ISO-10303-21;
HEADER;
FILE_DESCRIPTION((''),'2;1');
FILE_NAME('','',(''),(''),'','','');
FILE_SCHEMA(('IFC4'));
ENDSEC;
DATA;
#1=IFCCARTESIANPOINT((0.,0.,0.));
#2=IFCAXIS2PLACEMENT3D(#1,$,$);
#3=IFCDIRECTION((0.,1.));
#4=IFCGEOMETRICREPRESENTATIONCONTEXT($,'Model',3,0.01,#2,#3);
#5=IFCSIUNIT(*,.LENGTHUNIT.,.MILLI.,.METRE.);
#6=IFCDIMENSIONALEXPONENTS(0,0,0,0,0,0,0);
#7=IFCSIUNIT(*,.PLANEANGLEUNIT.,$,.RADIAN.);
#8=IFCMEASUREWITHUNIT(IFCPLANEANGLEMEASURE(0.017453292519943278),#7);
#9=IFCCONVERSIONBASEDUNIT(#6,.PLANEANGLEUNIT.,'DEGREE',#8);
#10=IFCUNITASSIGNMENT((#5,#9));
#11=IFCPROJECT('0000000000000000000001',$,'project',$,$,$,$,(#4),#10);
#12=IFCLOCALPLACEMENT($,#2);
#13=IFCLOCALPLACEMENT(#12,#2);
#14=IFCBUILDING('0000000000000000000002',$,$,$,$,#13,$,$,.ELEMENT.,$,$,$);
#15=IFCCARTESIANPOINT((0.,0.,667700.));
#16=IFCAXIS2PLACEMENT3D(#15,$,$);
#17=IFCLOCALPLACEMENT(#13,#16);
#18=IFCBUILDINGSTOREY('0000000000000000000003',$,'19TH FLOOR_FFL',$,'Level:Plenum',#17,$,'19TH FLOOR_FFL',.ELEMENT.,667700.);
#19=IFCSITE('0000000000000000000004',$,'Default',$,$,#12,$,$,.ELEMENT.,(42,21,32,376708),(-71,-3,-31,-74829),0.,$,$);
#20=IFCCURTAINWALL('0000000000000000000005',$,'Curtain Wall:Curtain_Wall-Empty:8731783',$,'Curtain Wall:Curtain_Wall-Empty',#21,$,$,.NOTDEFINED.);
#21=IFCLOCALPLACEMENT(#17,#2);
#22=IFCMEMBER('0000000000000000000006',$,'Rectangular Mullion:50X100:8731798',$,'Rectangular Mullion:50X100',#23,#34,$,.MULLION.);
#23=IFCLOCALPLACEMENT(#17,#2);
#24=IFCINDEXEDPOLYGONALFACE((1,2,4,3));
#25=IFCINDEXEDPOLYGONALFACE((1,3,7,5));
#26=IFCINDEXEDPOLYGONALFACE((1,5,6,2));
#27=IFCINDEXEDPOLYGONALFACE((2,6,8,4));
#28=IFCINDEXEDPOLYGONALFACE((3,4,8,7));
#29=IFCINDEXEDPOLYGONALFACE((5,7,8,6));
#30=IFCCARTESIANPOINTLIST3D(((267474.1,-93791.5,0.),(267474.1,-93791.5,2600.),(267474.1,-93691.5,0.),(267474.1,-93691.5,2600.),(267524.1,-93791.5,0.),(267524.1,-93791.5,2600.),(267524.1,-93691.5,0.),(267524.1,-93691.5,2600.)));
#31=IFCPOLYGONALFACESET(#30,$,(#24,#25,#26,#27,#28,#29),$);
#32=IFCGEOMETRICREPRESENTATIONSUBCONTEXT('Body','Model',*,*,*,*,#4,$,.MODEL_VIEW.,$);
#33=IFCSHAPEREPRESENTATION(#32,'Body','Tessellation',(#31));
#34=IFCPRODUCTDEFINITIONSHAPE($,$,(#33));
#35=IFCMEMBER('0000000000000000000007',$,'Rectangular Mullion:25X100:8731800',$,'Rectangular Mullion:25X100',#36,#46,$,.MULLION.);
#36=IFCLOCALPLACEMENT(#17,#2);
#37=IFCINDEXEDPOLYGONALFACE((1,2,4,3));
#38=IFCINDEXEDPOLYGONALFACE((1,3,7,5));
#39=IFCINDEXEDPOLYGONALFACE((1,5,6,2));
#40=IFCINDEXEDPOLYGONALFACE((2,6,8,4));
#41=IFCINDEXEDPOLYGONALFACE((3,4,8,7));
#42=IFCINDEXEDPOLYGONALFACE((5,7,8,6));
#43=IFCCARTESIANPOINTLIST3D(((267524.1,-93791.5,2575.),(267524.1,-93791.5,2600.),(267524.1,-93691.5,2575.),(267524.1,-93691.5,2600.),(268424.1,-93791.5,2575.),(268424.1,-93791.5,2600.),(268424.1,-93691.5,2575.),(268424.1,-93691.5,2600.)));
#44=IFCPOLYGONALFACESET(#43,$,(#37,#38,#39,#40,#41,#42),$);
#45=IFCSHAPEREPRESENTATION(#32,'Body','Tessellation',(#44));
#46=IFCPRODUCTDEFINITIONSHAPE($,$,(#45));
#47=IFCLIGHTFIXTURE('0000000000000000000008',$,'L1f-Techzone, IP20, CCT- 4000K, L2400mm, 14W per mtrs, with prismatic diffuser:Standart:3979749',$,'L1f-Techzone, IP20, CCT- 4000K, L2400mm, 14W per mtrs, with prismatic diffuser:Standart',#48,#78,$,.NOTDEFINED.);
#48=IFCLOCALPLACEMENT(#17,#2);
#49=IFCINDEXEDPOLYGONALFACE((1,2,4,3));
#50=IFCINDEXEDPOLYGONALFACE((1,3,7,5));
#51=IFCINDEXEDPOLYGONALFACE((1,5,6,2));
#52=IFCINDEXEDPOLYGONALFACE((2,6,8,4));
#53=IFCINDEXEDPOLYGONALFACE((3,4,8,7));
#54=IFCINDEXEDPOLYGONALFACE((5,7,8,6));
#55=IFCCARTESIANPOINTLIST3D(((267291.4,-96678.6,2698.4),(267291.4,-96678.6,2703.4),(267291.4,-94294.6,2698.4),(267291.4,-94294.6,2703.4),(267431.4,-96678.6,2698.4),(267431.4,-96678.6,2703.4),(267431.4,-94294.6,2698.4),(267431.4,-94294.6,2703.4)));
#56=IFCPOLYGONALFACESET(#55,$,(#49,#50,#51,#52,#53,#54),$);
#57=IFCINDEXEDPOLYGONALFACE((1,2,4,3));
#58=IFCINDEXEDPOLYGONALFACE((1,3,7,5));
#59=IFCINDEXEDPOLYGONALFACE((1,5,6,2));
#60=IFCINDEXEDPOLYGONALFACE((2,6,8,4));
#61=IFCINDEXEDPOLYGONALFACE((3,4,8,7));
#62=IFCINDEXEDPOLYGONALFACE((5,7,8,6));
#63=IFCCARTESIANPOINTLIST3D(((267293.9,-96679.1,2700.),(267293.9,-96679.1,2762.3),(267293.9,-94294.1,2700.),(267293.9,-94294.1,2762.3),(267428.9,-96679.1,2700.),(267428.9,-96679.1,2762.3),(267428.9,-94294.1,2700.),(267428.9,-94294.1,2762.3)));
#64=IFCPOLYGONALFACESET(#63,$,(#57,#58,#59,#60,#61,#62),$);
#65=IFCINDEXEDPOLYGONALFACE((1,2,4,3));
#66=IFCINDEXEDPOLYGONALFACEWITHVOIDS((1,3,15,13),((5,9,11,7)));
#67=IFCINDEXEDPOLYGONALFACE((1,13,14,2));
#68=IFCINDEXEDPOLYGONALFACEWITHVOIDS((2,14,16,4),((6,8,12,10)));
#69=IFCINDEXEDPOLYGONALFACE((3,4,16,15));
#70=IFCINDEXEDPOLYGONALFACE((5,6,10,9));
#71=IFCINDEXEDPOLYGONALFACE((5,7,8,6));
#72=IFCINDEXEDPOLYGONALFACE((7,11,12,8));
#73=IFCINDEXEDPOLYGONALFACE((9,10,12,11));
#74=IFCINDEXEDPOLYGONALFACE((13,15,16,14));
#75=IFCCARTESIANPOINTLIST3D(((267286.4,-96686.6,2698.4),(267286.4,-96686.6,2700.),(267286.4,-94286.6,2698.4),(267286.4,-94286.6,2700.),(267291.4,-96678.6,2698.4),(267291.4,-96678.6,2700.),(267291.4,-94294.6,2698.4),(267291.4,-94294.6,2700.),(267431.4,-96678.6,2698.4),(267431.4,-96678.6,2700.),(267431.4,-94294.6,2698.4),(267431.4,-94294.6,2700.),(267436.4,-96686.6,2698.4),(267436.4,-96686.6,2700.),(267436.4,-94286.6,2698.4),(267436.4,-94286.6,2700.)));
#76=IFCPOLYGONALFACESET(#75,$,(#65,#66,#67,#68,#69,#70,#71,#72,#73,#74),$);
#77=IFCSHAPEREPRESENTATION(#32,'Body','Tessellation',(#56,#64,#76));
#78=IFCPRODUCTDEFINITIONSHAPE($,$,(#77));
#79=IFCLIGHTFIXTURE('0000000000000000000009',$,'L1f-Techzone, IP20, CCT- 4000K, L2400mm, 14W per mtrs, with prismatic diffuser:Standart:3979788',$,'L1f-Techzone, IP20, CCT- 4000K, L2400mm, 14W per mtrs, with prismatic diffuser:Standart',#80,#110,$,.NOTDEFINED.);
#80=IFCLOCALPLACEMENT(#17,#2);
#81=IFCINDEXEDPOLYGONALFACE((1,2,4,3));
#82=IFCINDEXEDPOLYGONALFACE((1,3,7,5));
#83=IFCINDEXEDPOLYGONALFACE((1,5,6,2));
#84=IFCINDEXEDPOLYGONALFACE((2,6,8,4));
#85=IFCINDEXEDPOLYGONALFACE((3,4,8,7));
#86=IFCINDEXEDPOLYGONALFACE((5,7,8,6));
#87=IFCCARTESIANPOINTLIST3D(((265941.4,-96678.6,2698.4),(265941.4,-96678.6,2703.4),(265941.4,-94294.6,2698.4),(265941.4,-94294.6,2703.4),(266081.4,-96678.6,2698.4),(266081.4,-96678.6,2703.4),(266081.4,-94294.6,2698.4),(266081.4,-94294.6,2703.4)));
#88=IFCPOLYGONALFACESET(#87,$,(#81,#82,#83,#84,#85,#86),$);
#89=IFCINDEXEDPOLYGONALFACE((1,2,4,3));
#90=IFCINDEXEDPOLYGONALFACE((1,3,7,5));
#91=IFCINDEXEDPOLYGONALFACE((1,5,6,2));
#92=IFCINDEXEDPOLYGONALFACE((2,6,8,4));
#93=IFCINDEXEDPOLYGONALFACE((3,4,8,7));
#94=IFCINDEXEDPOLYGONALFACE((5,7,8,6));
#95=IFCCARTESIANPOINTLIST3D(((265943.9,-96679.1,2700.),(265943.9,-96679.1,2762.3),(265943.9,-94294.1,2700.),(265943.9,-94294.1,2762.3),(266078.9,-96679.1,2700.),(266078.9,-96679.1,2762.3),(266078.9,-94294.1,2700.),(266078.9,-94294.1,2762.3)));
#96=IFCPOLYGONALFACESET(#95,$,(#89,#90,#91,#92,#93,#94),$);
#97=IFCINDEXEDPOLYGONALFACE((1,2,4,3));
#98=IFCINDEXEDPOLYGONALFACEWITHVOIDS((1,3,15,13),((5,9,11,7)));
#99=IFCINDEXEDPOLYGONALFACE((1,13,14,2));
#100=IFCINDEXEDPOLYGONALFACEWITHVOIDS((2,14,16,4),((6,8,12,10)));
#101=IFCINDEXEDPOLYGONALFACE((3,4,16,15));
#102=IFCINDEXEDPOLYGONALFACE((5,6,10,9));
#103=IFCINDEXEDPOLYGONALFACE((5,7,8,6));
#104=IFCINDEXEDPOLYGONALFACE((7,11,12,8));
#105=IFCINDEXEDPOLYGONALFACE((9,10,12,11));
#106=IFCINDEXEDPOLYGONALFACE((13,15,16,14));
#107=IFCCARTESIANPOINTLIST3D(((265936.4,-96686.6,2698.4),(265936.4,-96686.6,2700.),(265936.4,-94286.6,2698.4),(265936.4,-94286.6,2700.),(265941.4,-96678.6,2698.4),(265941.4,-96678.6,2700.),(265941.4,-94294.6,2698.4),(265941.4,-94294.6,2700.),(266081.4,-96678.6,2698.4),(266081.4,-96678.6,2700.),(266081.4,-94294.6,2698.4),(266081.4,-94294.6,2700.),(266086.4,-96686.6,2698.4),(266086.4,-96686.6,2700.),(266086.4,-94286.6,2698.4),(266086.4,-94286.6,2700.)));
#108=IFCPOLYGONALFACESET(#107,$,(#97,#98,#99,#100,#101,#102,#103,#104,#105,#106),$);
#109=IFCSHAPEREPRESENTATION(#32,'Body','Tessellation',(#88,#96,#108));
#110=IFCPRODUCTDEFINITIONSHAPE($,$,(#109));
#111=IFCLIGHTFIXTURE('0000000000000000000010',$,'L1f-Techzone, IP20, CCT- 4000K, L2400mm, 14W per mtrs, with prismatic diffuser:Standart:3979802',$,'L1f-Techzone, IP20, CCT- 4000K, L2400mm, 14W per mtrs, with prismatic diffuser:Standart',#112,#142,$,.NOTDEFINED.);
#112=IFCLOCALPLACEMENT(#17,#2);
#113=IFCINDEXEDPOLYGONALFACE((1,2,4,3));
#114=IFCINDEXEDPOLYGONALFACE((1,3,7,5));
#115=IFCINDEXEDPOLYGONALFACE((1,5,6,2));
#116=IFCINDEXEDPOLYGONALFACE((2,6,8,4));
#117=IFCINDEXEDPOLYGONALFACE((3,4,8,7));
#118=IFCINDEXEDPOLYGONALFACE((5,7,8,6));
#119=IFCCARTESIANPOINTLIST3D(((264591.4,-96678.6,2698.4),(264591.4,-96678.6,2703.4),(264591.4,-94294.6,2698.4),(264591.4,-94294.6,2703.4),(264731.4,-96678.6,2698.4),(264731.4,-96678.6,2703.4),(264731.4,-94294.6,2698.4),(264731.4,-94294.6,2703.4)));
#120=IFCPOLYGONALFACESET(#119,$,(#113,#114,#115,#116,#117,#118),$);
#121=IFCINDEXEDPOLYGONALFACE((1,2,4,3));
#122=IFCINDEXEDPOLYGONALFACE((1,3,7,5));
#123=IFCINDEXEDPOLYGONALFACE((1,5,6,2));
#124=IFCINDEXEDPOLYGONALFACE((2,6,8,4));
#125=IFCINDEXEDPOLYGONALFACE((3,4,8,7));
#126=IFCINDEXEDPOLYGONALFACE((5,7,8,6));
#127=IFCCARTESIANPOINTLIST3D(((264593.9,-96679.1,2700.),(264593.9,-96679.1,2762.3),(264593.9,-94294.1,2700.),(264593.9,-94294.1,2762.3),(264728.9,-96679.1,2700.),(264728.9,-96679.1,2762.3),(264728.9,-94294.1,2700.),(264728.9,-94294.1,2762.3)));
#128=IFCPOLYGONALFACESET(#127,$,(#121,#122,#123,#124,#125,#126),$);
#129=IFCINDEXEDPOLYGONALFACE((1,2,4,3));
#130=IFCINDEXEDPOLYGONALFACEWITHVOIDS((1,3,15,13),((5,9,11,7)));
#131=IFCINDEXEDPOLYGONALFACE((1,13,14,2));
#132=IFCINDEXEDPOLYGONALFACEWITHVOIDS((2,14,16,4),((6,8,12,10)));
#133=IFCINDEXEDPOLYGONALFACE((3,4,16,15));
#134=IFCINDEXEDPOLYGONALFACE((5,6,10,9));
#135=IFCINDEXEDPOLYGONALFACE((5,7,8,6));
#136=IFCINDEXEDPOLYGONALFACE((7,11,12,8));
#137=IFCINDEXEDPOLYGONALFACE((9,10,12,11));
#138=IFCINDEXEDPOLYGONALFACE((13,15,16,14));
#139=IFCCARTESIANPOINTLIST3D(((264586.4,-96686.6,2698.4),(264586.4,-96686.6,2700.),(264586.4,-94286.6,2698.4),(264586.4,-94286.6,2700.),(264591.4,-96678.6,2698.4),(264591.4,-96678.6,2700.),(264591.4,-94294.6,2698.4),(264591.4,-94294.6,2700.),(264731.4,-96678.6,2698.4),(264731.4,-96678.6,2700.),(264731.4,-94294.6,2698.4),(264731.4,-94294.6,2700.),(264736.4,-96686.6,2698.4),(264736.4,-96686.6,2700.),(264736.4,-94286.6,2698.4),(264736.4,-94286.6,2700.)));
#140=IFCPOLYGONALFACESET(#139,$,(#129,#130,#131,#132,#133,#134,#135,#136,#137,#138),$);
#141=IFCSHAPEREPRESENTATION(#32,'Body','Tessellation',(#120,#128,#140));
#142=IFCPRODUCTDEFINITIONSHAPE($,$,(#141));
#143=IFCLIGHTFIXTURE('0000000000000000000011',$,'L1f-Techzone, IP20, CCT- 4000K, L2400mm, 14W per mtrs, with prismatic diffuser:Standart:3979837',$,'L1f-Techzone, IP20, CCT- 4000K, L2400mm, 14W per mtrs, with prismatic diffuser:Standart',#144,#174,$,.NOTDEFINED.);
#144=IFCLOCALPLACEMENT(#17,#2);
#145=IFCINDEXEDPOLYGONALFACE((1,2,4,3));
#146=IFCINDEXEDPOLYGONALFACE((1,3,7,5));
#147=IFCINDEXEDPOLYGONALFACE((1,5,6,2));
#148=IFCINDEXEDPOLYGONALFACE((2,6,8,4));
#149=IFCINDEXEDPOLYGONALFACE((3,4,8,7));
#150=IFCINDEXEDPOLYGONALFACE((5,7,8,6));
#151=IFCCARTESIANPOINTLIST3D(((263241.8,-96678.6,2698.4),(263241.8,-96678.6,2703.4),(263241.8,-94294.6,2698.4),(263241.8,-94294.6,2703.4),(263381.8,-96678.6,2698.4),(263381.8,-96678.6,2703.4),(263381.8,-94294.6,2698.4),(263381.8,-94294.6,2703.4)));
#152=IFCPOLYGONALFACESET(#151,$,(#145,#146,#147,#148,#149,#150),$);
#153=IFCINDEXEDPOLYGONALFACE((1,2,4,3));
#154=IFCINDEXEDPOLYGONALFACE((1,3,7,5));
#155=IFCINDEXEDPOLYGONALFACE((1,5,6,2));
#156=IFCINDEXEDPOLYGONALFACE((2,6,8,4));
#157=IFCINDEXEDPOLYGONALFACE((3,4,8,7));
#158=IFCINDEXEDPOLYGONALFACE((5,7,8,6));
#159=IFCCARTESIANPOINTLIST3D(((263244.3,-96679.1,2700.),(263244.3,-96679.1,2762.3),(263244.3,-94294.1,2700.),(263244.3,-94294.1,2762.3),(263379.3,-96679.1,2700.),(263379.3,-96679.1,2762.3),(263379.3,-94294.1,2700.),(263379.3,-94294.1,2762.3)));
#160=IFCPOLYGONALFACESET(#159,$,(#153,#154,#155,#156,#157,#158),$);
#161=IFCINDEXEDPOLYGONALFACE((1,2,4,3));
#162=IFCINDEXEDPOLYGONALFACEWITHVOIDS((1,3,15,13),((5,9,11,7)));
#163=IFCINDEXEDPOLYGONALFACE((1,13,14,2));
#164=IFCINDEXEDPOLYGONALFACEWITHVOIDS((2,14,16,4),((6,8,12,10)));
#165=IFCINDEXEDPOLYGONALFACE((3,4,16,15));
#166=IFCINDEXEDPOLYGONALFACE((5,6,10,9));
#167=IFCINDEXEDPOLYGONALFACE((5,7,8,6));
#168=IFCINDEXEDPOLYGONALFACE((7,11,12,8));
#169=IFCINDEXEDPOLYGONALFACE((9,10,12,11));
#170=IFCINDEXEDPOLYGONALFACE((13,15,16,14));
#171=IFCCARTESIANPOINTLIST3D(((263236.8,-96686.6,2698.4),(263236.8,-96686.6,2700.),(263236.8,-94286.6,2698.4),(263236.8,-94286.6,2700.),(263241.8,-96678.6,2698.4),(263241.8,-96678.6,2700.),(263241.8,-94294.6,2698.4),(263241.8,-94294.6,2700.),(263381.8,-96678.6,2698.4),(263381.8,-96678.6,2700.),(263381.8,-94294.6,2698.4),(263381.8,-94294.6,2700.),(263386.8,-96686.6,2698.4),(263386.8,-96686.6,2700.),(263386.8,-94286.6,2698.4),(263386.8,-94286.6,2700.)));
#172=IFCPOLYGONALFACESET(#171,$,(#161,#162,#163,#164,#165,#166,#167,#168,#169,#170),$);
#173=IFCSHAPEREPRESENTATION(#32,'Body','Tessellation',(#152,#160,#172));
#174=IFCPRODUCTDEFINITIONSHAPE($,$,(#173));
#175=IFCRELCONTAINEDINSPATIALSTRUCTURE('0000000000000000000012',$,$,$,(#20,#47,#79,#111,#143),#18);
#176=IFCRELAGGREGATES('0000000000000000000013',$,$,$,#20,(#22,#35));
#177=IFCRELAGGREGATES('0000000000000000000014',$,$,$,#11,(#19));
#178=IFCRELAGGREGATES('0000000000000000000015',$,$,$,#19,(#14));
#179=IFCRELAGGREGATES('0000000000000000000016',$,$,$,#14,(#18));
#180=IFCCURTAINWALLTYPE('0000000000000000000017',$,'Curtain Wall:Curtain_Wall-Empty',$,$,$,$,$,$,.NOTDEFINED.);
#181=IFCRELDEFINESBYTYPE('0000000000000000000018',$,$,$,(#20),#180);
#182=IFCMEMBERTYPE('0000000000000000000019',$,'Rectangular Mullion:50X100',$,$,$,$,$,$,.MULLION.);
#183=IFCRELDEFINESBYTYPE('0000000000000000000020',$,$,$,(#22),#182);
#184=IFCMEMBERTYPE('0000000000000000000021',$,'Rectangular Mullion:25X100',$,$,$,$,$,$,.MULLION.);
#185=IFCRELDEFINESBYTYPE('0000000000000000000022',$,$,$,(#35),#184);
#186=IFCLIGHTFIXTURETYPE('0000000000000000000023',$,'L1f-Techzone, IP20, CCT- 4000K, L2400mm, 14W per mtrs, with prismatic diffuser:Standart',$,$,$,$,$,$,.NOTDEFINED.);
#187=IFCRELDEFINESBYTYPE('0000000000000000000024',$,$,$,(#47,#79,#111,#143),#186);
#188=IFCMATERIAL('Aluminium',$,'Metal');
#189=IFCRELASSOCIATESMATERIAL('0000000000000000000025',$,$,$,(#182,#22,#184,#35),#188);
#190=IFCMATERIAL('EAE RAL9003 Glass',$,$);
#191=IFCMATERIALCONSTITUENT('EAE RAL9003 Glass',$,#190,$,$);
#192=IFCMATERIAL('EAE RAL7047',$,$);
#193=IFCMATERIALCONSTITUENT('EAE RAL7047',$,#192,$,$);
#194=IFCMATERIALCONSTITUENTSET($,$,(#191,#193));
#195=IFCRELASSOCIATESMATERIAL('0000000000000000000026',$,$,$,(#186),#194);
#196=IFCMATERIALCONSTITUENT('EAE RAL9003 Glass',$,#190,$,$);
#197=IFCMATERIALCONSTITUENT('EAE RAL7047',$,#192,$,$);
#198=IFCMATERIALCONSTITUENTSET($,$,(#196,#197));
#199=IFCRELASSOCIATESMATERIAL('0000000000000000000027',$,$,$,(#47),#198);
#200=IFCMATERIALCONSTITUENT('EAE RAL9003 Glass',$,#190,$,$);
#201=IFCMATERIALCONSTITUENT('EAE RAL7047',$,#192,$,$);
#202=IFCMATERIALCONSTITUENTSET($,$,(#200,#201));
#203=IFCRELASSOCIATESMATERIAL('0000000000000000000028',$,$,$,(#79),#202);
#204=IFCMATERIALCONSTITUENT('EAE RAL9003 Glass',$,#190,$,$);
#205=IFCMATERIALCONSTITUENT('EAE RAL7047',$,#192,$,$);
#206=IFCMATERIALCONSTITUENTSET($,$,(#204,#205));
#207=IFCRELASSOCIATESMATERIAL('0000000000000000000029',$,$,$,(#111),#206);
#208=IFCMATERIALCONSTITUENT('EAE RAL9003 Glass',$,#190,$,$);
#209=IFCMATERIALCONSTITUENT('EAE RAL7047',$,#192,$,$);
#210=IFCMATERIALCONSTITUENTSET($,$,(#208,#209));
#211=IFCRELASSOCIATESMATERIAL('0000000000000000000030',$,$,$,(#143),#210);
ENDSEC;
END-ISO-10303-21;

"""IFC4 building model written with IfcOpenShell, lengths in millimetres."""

from ifc_helpers import new_model, entity, si_unit, converted_unit, direction, frame, origin, place, context, subcontext, project, spatial, indexed_curve, outline, extrude, source, transform, mapped, material, constituent, constituent_set, type_object, type_shapes, element, aggregate, save


model = new_model("IFC4")

# Units and contexts
model_context = context("Model", 3, precision=0.01, world=origin(), true_north=direction((0.0, 1.0)))
body_context = subcontext(model_context, "Body", "Model", "MODEL_VIEW")
ifc_project = project(units=[si_unit("LENGTHUNIT", "METRE", prefix="MILLI"), converted_unit("PLANEANGLEUNIT", "DEGREE", entity("IfcPlaneAngleMeasure", 0.017453292519943278), si_unit("PLANEANGLEUNIT", "RADIAN"), dimensions=[0, 0, 0, 0, 0, 0, 0])], contexts=[model_context])

# Site, building, storey
site_placement = place(None, origin())
site = spatial("IfcSite", under=ifc_project, at=site_placement, Name="Default", CompositionType="ELEMENT", RefLatitude=(42, 21, 32, 376708), RefLongitude=(-71, -3, -31, -74829), RefElevation=0.0)
building_placement = place(site_placement, origin())
building = spatial("IfcBuilding", under=site, at=building_placement, CompositionType="ELEMENT")
storey_placement = place(building_placement, frame((0.0, 0.0, 667700.0)))
storey = spatial("IfcBuildingStorey", under=building, at=storey_placement, Name="19TH FLOOR_FFL", ObjectType="Level:Plenum", LongName="19TH FLOOR_FFL", CompositionType="ELEMENT", Elevation=667700.0)

# Curtain wall, members
curtain_wall_type = type_object("IfcCurtainWallType", Name="Curtain Wall:Curtain_Wall-Empty", PredefinedType="NOTDEFINED")
curtain_wall_placement = place(storey_placement, frame((0.0, 0.0, -667700.0)))
curtain_wall = element("IfcCurtainWall", 1, at=curtain_wall_placement, inside=storey, type_object=curtain_wall_type, Name="Curtain Wall:Curtain_Wall-Empty:8731783", ObjectType="Curtain Wall:Curtain_Wall-Empty", PredefinedType="NOTDEFINED")
ifc_material_1 = material(Name="Aluminium", Category="Metal")
member_type_1 = type_object("IfcMemberType", Name="Rectangular Mullion:50X100", PredefinedType="MULLION", material=ifc_material_1)
shared_shape_1 = source(origin(), body_context, "Body", "SweptSolid", [
    extrude(outline(indexed_curve([(-25.0, -50.0), (25.0, -50.0), (25.0, 50.0), (-25.0, 50.0), (-25.0, -50.0)], self_intersect=False)), frame((-25.0, 0.0, -2600.0), z_axis=(0.0, 0.0, 1.0), x_axis=(-1.0, 0.0, 0.0)), (0.0, 0.0, 1.0), 2600.0),
])
type_shapes(member_type_1, [shared_shape_1])
member_1_placement = place(curtain_wall_placement, frame((267474.1, -93741.5, 670300.0), z_axis=(0.0, 0.0, 1.0), x_axis=(-1.0, 0.0, 0.0)))
member_1 = element("IfcMember", 2, at=member_1_placement, type_object=member_type_1, material=ifc_material_1, Name="Rectangular Mullion:50X100:8731798", ObjectType="Rectangular Mullion:50X100", PredefinedType="MULLION", context=body_context, shape_type="MappedRepresentation", body=[
    mapped(shared_shape_1, transform((0.0, 0.0, 0.0), scale=1.0)),
])
member_type_2 = type_object("IfcMemberType", Name="Rectangular Mullion:25X100", PredefinedType="MULLION", material=ifc_material_1)
shared_shape_2 = source(origin(), body_context, "Body", "SweptSolid", [
    extrude(outline(indexed_curve([(-12.5, -50.0), (12.5, -50.0), (12.5, 50.0), (-12.5, 50.0), (-12.5, -50.0)], self_intersect=False)), frame((-12.5, 0.0, -900.0), z_axis=(0.0, 0.0, 1.0), x_axis=(-1.0, 0.0, 0.0)), (0.0, 0.0, 1.0), 900.0),
])
type_shapes(member_type_2, [shared_shape_2])
member_2_placement = place(curtain_wall_placement, frame((268424.1, -93741.5, 670300.0), z_axis=(1.0, 0.0, 0.0), x_axis=(0.0, 0.0, 1.0)))
member_2 = element("IfcMember", 3, at=member_2_placement, type_object=member_type_2, material=ifc_material_1, Name="Rectangular Mullion:25X100:8731800", ObjectType="Rectangular Mullion:25X100", PredefinedType="MULLION", context=body_context, shape_type="MappedRepresentation", body=[
    mapped(shared_shape_2, transform((0.0, 0.0, 0.0), scale=1.0)),
])
aggregate(curtain_wall, [member_1, member_2])

# Light fixtures
ifc_material_2 = material(Name="EAE RAL9003 Glass")
ifc_constituent_1 = constituent(ifc_material_2, Name="EAE RAL9003 Glass")
ifc_material_3 = material(Name="EAE RAL7047")
ifc_constituent_2 = constituent(ifc_material_3, Name="EAE RAL7047")
ifc_constituent_set_1 = constituent_set(constituents=[ifc_constituent_1, ifc_constituent_2])
ifc_constituent_3 = constituent(ifc_material_2, Name="EAE RAL9003 Glass")
ifc_constituent_4 = constituent(ifc_material_3, Name="EAE RAL7047")
ifc_constituent_set_2 = constituent_set(constituents=[ifc_constituent_3, ifc_constituent_4])
light_fixture_type_1 = type_object("IfcLightFixtureType", Name="L1f-Techzone, IP20, CCT- 4000K, L2400mm, 14W per mtrs, with prismatic diffuser:Standart", PredefinedType="NOTDEFINED", material=ifc_constituent_set_2)
shared_shape_3 = source(origin(), body_context, "Body", "SweptSolid", [
    extrude(outline(indexed_curve([(-70.0, -1192.0), (70.0, -1192.0), (70.0, 1192.0), (-70.0, 1192.0), (-70.0, -1192.0)], self_intersect=False)), frame((0.0, 0.0, -3.4), z_axis=(0.0, 0.0, 1.0), x_axis=(-1.0, 0.0, 0.0)), (0.0, 0.0, 1.0), 5.0),
    extrude(outline(indexed_curve([(-67.5, -1192.5), (67.5, -1192.5), (67.5, 1192.5), (-67.5, 1192.5), (-67.5, -1192.5)], self_intersect=False)), frame((0.0, 0.0, -62.3), z_axis=(0.0, 0.0, 1.0), x_axis=(-1.0, 0.0, 0.0)), (0.0, 0.0, 1.0), 62.3),
    extrude(outline(indexed_curve([(-75.0, -1200.0), (75.0, -1200.0), (75.0, 1200.0), (-75.0, 1200.0), (-75.0, -1200.0)], self_intersect=False), holes=[indexed_curve([(-70.0, -1192.0), (-70.0, 1192.0), (70.0, 1192.0), (70.0, -1192.0), (-70.0, -1192.0)], self_intersect=False)]), frame((0.0, 0.0, 0.0), z_axis=(0.0, 0.0, 1.0), x_axis=(-1.0, 0.0, 0.0)), (0.0, 0.0, 1.0), 1.6),
])
type_shapes(light_fixture_type_1, [shared_shape_3])
light_fixture_1_placement = place(storey_placement, frame((267361.4, -95486.6, 2700.0), z_axis=(0.0, 0.0, -1.0), x_axis=(1.0, 0.0, 0.0)))
element("IfcLightFixture", 4, at=light_fixture_1_placement, inside=storey, type_object=light_fixture_type_1, material=ifc_constituent_set_1, Name="L1f-Techzone, IP20, CCT- 4000K, L2400mm, 14W per mtrs, with prismatic diffuser:Standart:3979749", ObjectType="L1f-Techzone, IP20, CCT- 4000K, L2400mm, 14W per mtrs, with prismatic diffuser:Standart", PredefinedType="NOTDEFINED", context=body_context, shape_type="MappedRepresentation", body=[
    mapped(shared_shape_3, transform((0.0, 0.0, 0.0), scale=1.0)),
])
ifc_constituent_5 = constituent(ifc_material_2, Name="EAE RAL9003 Glass")
ifc_constituent_6 = constituent(ifc_material_3, Name="EAE RAL7047")
ifc_constituent_set_3 = constituent_set(constituents=[ifc_constituent_5, ifc_constituent_6])
light_fixture_2_placement = place(storey_placement, frame((266011.4, -95486.6, 2700.0), z_axis=(0.0, 0.0, -1.0), x_axis=(1.0, 0.0, 0.0)))
element("IfcLightFixture", 5, at=light_fixture_2_placement, inside=storey, type_object=light_fixture_type_1, material=ifc_constituent_set_3, Name="L1f-Techzone, IP20, CCT- 4000K, L2400mm, 14W per mtrs, with prismatic diffuser:Standart:3979788", ObjectType="L1f-Techzone, IP20, CCT- 4000K, L2400mm, 14W per mtrs, with prismatic diffuser:Standart", PredefinedType="NOTDEFINED", context=body_context, shape_type="MappedRepresentation", body=[
    mapped(shared_shape_3, transform((0.0, 0.0, 0.0), scale=1.0)),
])
ifc_constituent_7 = constituent(ifc_material_2, Name="EAE RAL9003 Glass")
ifc_constituent_8 = constituent(ifc_material_3, Name="EAE RAL7047")
ifc_constituent_set_4 = constituent_set(constituents=[ifc_constituent_7, ifc_constituent_8])
light_fixture_3_placement = place(storey_placement, frame((264661.4, -95486.6, 2700.0), z_axis=(0.0, 0.0, -1.0), x_axis=(1.0, 0.0, 0.0)))
element("IfcLightFixture", 6, at=light_fixture_3_placement, inside=storey, type_object=light_fixture_type_1, material=ifc_constituent_set_4, Name="L1f-Techzone, IP20, CCT- 4000K, L2400mm, 14W per mtrs, with prismatic diffuser:Standart:3979802", ObjectType="L1f-Techzone, IP20, CCT- 4000K, L2400mm, 14W per mtrs, with prismatic diffuser:Standart", PredefinedType="NOTDEFINED", context=body_context, shape_type="MappedRepresentation", body=[
    mapped(shared_shape_3, transform((0.0, 0.0, 0.0), scale=1.0)),
])
ifc_constituent_9 = constituent(ifc_material_2, Name="EAE RAL9003 Glass")
ifc_constituent_10 = constituent(ifc_material_3, Name="EAE RAL7047")
ifc_constituent_set_5 = constituent_set(constituents=[ifc_constituent_9, ifc_constituent_10])
light_fixture_4_placement = place(storey_placement, frame((263311.8, -95486.6, 2700.0), z_axis=(0.0, 0.0, -1.0), x_axis=(1.0, 0.0, 0.0)))
element("IfcLightFixture", 7, at=light_fixture_4_placement, inside=storey, type_object=light_fixture_type_1, material=ifc_constituent_set_5, Name="L1f-Techzone, IP20, CCT- 4000K, L2400mm, 14W per mtrs, with prismatic diffuser:Standart:3979837", ObjectType="L1f-Techzone, IP20, CCT- 4000K, L2400mm, 14W per mtrs, with prismatic diffuser:Standart", PredefinedType="NOTDEFINED", context=body_context, shape_type="MappedRepresentation", body=[
    mapped(shared_shape_3, transform((0.0, 0.0, 0.0), scale=1.0)),
])

save(model, "model.ifc")
